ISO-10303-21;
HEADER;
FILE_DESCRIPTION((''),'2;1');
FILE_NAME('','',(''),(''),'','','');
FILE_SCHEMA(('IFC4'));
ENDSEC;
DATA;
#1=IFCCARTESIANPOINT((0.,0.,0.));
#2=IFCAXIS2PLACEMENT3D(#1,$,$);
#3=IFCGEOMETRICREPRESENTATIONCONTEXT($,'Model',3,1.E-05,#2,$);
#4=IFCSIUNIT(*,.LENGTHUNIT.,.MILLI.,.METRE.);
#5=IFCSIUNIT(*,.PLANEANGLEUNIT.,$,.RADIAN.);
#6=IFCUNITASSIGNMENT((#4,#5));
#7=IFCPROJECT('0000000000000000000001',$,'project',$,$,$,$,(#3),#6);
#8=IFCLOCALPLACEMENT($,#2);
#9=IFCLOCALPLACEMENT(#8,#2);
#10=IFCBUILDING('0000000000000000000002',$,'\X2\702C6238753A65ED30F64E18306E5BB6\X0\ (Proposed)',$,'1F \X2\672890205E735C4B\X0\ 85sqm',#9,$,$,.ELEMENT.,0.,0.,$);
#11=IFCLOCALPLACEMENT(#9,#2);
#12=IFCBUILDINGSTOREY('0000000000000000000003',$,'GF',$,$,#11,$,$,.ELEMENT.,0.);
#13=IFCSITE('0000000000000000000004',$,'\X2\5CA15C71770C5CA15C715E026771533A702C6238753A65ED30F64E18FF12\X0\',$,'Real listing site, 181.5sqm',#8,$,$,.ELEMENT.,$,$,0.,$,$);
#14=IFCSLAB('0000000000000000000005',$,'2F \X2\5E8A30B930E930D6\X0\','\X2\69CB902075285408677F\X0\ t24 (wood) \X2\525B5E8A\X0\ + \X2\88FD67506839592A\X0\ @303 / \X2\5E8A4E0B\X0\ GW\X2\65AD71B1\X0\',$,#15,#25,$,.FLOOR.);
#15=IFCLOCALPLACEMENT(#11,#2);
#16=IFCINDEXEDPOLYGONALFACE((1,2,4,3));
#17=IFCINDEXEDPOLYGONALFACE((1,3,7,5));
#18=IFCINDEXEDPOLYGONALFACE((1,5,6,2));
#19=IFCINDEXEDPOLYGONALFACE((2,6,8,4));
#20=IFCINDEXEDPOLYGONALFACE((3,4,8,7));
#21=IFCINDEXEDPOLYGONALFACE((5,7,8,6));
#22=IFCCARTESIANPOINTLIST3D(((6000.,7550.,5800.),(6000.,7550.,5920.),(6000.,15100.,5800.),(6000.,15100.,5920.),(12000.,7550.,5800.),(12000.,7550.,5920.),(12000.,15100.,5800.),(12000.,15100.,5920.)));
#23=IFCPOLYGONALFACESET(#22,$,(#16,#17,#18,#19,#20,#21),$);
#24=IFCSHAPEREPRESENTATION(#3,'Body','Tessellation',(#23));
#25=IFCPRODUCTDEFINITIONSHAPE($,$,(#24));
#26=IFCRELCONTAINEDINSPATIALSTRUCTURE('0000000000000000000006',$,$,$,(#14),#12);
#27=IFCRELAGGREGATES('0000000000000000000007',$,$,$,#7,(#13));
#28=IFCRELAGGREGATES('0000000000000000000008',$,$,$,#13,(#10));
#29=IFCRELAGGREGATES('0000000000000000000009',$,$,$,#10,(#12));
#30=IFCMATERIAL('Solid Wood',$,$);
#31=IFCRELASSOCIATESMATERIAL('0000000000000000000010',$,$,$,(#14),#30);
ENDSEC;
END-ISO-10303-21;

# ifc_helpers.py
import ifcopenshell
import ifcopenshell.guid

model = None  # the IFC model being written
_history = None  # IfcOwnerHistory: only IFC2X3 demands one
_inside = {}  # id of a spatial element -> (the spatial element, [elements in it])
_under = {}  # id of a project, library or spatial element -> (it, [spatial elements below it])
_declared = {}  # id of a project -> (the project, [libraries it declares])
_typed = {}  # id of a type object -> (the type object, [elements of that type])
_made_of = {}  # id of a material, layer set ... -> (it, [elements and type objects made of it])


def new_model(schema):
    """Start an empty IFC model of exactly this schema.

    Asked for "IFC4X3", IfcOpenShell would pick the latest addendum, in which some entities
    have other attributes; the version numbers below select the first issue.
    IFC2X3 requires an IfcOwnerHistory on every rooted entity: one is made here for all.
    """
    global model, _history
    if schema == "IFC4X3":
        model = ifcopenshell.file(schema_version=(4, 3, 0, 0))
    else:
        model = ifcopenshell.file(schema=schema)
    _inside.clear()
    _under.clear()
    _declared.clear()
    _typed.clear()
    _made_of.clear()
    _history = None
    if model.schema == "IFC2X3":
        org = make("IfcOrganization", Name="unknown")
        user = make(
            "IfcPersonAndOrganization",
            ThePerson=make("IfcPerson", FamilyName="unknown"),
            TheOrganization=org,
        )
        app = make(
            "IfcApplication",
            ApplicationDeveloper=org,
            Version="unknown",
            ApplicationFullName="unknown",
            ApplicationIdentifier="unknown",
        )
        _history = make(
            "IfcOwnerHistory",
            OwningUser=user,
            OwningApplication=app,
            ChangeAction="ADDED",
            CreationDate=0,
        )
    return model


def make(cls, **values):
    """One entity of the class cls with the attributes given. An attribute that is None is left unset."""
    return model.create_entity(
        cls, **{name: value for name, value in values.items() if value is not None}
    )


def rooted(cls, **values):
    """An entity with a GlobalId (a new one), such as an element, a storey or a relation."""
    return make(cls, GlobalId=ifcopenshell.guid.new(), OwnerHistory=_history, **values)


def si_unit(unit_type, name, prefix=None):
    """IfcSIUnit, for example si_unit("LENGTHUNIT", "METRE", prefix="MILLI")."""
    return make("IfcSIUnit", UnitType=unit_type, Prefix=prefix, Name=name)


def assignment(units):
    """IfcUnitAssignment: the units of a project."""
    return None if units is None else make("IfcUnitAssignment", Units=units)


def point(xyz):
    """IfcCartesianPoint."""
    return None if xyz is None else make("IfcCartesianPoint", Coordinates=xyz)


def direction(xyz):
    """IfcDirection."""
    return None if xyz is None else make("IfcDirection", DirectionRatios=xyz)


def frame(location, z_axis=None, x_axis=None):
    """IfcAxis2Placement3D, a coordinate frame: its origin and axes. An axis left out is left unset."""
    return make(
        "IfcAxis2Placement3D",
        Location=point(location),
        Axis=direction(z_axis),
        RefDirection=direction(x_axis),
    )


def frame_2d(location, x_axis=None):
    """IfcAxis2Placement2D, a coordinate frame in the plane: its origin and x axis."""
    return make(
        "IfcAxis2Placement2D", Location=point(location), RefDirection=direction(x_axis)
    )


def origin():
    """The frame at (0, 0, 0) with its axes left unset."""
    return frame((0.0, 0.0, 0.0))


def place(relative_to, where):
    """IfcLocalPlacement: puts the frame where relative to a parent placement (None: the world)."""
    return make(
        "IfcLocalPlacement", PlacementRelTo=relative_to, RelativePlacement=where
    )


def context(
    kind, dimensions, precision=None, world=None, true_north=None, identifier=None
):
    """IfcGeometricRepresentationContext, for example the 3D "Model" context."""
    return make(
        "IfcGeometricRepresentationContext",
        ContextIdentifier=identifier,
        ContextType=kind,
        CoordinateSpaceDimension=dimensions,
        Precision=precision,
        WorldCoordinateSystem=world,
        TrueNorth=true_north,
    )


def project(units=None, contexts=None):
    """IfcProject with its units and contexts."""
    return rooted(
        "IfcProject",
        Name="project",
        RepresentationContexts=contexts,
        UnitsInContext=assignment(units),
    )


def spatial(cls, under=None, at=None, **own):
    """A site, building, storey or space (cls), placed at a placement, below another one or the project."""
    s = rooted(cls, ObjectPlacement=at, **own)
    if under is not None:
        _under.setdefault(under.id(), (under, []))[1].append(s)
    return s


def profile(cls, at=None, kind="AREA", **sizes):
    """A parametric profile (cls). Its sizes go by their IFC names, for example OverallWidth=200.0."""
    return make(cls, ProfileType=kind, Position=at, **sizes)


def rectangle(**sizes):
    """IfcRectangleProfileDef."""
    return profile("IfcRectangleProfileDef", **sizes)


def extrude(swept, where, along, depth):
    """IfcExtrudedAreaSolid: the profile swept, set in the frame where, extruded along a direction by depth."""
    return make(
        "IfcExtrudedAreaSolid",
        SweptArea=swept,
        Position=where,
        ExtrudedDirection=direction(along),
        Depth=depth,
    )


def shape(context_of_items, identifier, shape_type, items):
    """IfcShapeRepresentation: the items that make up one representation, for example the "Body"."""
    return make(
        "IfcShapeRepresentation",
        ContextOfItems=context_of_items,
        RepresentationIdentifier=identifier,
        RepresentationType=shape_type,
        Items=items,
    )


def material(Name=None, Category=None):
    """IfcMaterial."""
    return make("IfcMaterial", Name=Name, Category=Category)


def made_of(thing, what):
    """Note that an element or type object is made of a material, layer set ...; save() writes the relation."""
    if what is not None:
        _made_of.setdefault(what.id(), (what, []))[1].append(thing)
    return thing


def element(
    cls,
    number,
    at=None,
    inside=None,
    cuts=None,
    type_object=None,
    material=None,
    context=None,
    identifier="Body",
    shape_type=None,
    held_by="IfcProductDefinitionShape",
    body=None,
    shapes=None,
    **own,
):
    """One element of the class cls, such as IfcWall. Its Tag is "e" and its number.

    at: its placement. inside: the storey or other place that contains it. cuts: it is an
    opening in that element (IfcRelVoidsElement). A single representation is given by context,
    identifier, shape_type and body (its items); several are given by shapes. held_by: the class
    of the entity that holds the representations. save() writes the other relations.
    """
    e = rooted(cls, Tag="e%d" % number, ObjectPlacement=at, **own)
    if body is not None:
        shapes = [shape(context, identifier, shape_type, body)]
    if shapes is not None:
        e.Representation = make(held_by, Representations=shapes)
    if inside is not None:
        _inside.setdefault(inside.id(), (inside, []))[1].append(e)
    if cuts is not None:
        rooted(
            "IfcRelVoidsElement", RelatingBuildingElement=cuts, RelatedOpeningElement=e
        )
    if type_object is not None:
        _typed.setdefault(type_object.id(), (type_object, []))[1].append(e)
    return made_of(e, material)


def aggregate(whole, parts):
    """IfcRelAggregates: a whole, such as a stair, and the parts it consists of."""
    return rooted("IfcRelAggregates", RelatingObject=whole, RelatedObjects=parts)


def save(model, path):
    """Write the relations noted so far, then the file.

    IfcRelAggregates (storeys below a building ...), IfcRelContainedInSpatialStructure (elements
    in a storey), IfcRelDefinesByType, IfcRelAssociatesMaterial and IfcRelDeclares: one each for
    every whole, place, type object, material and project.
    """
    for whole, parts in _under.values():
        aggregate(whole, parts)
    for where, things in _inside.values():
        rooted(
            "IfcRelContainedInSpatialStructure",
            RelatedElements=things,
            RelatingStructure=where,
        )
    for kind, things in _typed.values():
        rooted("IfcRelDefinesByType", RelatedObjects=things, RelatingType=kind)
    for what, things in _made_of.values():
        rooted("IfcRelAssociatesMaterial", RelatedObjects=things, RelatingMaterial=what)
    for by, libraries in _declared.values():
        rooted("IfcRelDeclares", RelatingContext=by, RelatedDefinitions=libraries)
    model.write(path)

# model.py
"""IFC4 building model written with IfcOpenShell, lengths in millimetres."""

from ifc_helpers import new_model, si_unit, frame, frame_2d, origin, place, context, project, spatial, rectangle, extrude, material, element, save


model = new_model("IFC4")

# Units and contexts
model_context = context("Model", 3, precision=1e-05, world=origin())
ifc_project = project(units=[si_unit("LENGTHUNIT", "METRE", prefix="MILLI"), si_unit("PLANEANGLEUNIT", "RADIAN")], contexts=[model_context])

# Site, building, storey
site_placement = place(None, origin())
site = spatial("IfcSite", under=ifc_project, at=site_placement, Name="岡山県岡山市東区瀬戸町旭ヶ丘２", ObjectType="Real listing site, 181.5sqm", CompositionType="ELEMENT", RefElevation=0.0)
building_placement = place(site_placement, origin())
building = spatial("IfcBuilding", under=site, at=building_placement, Name="瀬戸町旭ヶ丘の家 (Proposed)", ObjectType="1F 木造平屋 85sqm", CompositionType="ELEMENT", ElevationOfRefHeight=0.0, ElevationOfTerrain=0.0)
storey_placement = place(building_placement, origin())
storey = spatial("IfcBuildingStorey", under=building, at=storey_placement, Name="GF", CompositionType="ELEMENT", Elevation=0.0)

# Slab
ifc_material_1 = material(Name="Solid Wood")
slab_placement = place(storey_placement, frame((3000.0, 3775.0, 2900.0)))
element("IfcSlab", 1, at=slab_placement, inside=storey, material=ifc_material_1, Name="2F 床スラブ", Description="構造用合板 t24 (wood) 剛床 + 製材根太 @303 / 床下 GW断熱", PredefinedType="FLOOR", context=model_context, shape_type="SweptSolid", body=[
    extrude(rectangle(XDim=6000.0, YDim=7550.0, at=frame_2d((3000.0, 3775.0))), frame((3000.0, 3775.0, 2900.0)), (0.0, 0.0, 1.0), 120.0),
])

save(model, "model.ifc")
